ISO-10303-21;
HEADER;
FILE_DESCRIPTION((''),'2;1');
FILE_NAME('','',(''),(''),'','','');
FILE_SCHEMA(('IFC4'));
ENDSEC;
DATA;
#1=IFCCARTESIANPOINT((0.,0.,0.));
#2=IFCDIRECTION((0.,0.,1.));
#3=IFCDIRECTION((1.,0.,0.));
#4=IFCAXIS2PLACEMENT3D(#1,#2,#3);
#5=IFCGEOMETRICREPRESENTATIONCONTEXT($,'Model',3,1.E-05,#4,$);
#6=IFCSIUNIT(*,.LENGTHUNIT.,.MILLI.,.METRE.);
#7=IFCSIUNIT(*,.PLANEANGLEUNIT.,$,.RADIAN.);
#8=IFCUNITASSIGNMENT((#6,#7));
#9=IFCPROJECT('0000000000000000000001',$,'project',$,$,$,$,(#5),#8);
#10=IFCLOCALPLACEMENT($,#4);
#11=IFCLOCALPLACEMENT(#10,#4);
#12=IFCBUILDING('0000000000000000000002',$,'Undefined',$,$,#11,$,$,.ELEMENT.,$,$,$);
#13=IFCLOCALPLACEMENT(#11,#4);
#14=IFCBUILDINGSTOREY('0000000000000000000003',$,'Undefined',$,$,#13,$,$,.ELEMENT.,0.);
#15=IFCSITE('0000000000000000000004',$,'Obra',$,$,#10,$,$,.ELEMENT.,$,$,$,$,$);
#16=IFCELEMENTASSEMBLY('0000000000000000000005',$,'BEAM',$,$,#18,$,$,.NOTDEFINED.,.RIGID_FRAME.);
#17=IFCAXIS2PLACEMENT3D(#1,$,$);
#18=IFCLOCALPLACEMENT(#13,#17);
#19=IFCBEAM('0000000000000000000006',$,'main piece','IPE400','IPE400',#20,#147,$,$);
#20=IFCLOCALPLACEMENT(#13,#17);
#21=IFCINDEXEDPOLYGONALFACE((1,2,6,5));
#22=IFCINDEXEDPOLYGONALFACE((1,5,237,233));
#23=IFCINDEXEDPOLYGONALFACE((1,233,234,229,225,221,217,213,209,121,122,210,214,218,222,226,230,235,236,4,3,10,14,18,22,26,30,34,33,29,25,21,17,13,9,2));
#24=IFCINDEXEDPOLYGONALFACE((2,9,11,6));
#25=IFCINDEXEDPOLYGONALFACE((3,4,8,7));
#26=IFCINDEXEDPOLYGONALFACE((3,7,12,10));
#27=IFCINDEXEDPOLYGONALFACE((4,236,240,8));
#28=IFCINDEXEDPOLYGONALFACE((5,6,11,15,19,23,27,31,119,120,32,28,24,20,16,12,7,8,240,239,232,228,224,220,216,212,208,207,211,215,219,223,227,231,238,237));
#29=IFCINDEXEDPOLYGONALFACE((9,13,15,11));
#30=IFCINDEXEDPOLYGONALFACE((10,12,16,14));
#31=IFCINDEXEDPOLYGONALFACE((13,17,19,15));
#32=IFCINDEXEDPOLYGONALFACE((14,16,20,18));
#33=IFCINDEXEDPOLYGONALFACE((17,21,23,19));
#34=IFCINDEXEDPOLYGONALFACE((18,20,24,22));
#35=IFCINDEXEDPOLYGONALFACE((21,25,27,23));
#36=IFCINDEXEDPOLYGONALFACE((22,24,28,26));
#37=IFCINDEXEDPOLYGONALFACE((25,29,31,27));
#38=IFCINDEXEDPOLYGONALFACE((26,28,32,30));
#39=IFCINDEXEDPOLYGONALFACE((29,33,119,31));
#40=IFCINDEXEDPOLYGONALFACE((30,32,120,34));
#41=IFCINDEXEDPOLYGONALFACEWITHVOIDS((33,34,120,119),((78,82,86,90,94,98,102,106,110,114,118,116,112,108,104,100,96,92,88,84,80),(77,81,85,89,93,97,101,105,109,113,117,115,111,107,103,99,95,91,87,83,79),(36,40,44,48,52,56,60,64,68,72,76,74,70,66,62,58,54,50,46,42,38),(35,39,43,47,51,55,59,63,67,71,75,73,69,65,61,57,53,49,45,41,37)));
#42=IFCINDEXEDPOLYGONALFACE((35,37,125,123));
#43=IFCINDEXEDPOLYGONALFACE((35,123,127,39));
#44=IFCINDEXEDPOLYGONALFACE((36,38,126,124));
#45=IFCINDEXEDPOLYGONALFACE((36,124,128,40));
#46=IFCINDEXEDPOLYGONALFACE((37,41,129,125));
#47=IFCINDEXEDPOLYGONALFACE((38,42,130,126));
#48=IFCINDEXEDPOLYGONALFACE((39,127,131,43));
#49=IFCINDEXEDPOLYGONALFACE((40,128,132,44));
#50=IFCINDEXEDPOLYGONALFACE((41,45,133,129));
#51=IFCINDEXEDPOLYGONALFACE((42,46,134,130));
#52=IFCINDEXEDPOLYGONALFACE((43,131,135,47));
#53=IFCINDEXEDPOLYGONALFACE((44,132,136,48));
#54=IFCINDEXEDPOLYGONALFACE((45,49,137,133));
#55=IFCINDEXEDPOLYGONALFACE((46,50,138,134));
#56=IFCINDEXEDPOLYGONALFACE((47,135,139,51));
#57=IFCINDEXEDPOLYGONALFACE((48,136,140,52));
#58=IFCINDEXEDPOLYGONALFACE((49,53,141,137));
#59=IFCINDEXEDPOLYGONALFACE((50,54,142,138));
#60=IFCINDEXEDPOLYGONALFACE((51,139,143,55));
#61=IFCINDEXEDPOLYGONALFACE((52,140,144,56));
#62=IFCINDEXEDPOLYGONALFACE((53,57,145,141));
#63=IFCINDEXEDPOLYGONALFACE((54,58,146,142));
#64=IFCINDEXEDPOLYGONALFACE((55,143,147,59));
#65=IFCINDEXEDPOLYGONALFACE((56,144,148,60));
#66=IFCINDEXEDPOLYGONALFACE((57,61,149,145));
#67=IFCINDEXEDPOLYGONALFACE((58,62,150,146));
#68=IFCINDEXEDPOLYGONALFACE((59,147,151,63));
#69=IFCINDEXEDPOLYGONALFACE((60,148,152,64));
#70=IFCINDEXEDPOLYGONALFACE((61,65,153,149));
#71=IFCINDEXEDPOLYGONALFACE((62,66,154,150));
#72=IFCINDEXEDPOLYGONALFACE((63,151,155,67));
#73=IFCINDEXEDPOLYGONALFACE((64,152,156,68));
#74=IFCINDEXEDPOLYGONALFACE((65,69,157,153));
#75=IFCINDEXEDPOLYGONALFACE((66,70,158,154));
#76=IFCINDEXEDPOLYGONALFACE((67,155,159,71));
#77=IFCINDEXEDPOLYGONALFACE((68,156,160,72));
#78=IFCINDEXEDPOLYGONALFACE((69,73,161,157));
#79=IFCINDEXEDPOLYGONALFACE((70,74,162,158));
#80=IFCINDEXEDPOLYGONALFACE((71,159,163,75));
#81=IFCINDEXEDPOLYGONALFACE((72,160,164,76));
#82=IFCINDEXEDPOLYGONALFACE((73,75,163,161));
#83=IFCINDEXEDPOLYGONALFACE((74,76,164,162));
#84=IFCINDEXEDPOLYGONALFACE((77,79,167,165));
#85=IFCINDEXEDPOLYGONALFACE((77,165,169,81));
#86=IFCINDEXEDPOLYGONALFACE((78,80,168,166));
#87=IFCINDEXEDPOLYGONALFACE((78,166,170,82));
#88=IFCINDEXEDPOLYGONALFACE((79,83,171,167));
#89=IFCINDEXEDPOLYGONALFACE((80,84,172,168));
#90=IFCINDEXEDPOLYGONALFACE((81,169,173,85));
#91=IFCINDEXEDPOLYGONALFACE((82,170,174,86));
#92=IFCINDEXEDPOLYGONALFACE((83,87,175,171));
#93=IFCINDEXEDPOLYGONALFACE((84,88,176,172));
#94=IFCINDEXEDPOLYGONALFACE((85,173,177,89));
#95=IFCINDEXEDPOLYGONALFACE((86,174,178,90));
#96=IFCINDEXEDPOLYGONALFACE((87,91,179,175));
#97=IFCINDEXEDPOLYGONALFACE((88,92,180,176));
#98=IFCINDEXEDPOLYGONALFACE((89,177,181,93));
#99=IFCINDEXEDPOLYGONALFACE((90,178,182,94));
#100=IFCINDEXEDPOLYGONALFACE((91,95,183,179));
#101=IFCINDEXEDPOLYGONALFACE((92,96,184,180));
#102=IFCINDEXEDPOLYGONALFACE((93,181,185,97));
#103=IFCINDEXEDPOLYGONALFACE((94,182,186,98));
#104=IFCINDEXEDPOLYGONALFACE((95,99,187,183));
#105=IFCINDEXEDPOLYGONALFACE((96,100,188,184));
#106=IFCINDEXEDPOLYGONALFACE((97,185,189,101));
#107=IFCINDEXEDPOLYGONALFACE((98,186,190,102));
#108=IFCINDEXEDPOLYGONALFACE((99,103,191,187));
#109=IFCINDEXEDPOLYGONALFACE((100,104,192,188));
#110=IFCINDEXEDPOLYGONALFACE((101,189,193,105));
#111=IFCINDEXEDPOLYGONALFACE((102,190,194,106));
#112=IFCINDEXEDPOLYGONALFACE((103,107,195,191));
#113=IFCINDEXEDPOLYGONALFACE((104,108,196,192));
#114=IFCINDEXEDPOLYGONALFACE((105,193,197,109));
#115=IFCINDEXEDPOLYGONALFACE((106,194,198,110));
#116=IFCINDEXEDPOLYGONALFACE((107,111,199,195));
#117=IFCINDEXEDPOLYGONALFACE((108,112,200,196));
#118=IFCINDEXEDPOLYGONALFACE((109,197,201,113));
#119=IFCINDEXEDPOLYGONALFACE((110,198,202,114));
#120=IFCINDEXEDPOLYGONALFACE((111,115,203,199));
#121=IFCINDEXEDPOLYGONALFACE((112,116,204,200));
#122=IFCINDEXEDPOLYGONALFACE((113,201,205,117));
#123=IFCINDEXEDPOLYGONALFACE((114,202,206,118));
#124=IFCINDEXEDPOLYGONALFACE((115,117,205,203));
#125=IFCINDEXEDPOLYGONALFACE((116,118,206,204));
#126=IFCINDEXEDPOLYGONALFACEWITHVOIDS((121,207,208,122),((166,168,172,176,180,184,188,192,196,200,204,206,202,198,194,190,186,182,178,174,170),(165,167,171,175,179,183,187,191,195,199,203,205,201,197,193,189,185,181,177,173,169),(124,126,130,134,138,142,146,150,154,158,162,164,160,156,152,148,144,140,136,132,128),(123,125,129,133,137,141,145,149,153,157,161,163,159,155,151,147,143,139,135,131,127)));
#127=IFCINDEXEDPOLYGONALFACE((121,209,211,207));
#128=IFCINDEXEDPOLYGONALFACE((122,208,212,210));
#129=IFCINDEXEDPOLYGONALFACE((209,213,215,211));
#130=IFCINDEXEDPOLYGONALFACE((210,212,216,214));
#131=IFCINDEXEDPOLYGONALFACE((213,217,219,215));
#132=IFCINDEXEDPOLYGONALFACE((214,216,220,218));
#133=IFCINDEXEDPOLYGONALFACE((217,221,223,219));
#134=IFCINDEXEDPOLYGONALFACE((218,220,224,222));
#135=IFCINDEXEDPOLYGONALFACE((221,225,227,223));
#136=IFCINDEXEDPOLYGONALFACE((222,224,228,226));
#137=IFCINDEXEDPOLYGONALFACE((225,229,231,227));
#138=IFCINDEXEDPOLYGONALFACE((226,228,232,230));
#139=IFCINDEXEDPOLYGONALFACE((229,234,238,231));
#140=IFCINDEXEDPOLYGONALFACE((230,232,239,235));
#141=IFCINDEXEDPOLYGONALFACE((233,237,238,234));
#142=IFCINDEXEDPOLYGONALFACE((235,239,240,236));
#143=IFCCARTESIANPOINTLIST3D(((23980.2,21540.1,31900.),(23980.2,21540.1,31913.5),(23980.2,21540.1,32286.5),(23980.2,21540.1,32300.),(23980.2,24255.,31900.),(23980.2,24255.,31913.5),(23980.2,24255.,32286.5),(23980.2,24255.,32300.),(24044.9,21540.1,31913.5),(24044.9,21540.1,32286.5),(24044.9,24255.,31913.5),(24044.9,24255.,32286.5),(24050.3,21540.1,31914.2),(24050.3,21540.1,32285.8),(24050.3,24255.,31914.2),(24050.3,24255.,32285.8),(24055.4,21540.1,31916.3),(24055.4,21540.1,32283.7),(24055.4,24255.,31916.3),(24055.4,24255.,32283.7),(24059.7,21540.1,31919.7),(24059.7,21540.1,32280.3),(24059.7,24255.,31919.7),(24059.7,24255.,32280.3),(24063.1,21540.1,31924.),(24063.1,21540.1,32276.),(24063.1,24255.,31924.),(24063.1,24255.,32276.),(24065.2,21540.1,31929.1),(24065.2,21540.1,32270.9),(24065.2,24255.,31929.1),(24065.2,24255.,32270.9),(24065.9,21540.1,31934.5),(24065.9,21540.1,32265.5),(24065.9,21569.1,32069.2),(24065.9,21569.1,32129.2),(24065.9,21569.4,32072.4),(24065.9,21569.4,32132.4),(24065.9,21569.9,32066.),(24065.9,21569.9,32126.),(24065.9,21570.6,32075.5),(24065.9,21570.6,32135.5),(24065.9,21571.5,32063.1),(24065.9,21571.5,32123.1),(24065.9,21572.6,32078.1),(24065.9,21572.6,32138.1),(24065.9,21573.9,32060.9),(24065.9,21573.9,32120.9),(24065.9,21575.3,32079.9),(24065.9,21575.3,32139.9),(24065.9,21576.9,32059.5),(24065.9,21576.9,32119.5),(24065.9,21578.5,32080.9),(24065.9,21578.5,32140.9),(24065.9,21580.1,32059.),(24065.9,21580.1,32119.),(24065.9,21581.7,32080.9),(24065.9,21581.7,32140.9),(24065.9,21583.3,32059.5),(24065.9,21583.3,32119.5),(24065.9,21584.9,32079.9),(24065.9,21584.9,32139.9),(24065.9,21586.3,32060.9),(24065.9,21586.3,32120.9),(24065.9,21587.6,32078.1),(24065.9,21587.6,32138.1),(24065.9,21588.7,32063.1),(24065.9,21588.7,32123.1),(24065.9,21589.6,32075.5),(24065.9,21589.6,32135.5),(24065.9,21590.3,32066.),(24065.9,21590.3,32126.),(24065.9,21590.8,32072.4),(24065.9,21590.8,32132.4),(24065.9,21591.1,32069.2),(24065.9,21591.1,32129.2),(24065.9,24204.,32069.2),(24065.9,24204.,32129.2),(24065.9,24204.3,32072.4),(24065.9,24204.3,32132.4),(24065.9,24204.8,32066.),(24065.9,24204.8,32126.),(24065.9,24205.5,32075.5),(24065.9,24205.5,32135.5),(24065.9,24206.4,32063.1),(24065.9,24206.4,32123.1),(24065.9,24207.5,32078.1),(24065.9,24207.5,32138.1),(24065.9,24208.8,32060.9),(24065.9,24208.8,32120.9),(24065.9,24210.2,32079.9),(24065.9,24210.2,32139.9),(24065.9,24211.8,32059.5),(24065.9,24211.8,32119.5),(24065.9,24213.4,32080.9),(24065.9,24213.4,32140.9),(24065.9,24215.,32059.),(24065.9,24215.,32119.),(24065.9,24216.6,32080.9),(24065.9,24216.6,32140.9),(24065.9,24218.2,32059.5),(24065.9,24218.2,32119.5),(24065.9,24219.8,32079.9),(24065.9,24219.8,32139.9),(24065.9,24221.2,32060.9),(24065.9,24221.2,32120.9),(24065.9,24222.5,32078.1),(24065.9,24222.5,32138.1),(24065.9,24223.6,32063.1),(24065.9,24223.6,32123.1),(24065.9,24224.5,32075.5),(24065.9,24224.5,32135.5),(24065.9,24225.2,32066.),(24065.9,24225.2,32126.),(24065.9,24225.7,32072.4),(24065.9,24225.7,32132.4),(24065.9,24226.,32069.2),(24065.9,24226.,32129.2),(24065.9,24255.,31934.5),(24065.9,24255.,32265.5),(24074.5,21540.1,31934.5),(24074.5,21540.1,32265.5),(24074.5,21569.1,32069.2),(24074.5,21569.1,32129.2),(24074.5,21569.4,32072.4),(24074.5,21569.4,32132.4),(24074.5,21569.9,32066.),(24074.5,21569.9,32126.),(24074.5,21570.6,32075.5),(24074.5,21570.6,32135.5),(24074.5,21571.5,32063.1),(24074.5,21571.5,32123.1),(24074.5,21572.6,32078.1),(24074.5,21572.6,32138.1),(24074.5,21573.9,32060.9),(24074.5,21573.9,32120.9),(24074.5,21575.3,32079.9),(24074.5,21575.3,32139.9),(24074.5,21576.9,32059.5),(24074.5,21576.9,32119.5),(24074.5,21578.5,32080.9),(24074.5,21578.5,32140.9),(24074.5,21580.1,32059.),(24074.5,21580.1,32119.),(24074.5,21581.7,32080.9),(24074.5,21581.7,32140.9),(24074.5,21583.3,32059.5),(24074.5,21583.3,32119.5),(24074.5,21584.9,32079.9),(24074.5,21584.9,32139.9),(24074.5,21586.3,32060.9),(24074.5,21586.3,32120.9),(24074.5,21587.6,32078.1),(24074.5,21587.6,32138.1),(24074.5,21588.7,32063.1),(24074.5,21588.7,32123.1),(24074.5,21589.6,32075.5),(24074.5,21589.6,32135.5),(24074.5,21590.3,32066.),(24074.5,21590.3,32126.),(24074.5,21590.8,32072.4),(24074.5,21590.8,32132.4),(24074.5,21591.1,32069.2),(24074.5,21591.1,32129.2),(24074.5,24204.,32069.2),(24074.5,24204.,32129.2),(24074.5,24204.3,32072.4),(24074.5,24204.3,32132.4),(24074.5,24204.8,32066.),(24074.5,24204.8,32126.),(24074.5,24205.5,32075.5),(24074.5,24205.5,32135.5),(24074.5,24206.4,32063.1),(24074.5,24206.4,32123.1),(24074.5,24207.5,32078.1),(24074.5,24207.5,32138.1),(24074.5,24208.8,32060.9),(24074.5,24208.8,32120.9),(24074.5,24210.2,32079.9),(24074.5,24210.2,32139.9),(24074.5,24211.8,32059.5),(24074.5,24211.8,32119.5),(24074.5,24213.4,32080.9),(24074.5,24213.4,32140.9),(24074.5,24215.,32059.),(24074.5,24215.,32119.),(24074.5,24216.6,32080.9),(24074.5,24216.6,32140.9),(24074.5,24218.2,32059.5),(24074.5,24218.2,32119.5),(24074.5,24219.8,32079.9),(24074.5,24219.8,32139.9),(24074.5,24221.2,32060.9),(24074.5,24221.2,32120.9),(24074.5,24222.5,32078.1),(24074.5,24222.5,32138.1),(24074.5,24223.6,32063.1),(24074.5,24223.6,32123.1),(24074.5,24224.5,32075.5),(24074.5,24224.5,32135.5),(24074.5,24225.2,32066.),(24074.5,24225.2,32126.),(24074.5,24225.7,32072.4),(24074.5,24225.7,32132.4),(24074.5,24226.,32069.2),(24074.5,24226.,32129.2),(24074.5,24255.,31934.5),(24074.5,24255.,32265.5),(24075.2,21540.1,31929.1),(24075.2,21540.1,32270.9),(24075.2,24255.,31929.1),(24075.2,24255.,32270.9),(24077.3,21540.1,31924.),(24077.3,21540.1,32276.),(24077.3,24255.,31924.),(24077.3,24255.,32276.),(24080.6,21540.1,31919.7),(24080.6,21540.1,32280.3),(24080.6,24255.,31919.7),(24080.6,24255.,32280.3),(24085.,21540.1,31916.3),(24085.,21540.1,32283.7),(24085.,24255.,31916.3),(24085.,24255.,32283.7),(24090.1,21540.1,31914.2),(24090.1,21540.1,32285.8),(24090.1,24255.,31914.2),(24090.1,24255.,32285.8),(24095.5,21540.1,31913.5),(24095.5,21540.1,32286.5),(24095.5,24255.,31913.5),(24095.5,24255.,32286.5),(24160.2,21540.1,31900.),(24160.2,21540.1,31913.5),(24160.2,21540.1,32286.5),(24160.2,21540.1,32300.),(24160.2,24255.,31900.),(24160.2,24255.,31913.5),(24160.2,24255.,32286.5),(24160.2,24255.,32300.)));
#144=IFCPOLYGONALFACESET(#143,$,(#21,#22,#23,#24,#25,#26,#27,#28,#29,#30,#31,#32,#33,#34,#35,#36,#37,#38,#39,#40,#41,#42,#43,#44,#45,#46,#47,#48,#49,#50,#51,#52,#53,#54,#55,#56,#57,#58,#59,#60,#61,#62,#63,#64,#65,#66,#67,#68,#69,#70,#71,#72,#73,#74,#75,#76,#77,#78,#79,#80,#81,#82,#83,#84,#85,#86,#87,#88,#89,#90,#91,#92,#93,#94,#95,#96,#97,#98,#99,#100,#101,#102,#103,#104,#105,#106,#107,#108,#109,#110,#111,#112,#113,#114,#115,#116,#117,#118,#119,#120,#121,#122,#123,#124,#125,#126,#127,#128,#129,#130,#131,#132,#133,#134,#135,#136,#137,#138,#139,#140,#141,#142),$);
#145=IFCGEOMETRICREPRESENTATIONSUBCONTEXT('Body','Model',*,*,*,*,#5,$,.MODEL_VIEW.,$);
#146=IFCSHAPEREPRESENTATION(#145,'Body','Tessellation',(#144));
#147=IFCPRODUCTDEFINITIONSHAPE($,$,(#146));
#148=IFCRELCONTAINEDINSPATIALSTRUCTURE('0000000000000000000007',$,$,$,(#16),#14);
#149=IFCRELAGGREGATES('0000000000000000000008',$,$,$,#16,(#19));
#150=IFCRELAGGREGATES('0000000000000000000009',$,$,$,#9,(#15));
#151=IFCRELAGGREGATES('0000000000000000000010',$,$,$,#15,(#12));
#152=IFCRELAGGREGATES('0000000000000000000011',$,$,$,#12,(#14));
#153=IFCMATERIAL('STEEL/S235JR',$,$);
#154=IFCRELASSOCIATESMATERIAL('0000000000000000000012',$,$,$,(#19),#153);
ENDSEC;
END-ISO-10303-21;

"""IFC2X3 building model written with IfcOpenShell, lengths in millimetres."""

from ifc_helpers import new_model, si_unit, frame, origin_with_axes, origin_2d_with_axis, place, context, subcontext, project, spatial, rectangle, circle, i_section, extrude, clip, halfspace, source, transform, mapped, material, element, aggregate, save


model = new_model("IFC2X3")

# Units and contexts
model_context = context("Model", 3, precision=1e-05, world=origin_with_axes())
body_context = subcontext(model_context, "Body", "Model", "MODEL_VIEW")
ifc_project = project(units=[si_unit("LENGTHUNIT", "METRE", prefix="MILLI"), si_unit("PLANEANGLEUNIT", "RADIAN")], contexts=[model_context])

# Site, building, storey
site_placement = place(None, origin_with_axes())
site = spatial("IfcSite", under=ifc_project, at=site_placement, Name="Obra", CompositionType="ELEMENT")
building_placement = place(site_placement, origin_with_axes())
building = spatial("IfcBuilding", under=site, at=building_placement, Name="Undefined", CompositionType="ELEMENT")
storey_placement = place(building_placement, origin_with_axes())
storey = spatial("IfcBuildingStorey", under=building, at=storey_placement, Name="Undefined", CompositionType="ELEMENT", Elevation=0.0)

# Shared definitions
ifc_material_1 = material(Name="STEEL/S235JR")

# Element assembly, beam, openings
assembly_1_placement = place(storey_placement, origin_with_axes())
assembly_1 = element("IfcElementAssembly", 1, at=assembly_1_placement, inside=storey, Name="BEAM", AssemblyPlace="NOTDEFINED", PredefinedType="RIGID_FRAME")
beam_1_placement = place(assembly_1_placement, frame((24070.2, 21550.1, 32100.0), z_axis=(0.0, 0.0, 1.0), x_axis=(0.0, 1.0, 0.0)))
beam_1 = element("IfcBeam", 2, at=beam_1_placement, material=ifc_material_1, Name="main piece", Description="IPE400", ObjectType="IPE400", context=body_context, shape_type="Clipping", body=[
    clip(clip(extrude(i_section(OverallWidth=180.0, OverallDepth=400.0, WebThickness=8.6, FlangeThickness=13.5, FilletRadius=21.0, at=origin_2d_with_axis()), frame((2704.9, 0.0, 0.0), z_axis=(-1.0, 0.0, 0.0), x_axis=(0.0, -1.0, 0.0)), (0.0, 0.0, 1.0), 2714.9), halfspace(frame((2704.9, 0.0, -300.0), z_axis=(-1.0, -0.000001, 0.0), x_axis=(-0.000002, 1.0, 0.0)), True)), halfspace(frame((-10.0, 0.0, -300.0), z_axis=(1.0, 0.0, 0.0), x_axis=(0.0, -1.0, 0.0)), True)),
])
opening_1_placement = place(assembly_1_placement, frame((24070.2, 21550.1, 32100.0), z_axis=(0.0, 0.0, 1.0), x_axis=(0.0, 1.0, 0.0)))
element("IfcOpeningElement", 3, at=opening_1_placement, cuts=beam_1, ObjectType="Recess", context=body_context, shape_type="SweptSolid", body=[
    extrude(rectangle(XDim=35.5, YDim=97.7, at=origin_2d_with_axis()), frame((-58.9, -91.0, -183.2), z_axis=(0.0, 1.0, 0.0), x_axis=(0.0, 0.0, -1.0)), (0.0, 0.0, 1.0), 182.0),
])
opening_2_placement = place(assembly_1_placement, frame((24070.2, 21550.1, 32100.0), z_axis=(0.0, 0.0, 1.0), x_axis=(0.0, 1.0, 0.0)))
element("IfcOpeningElement", 4, at=opening_2_placement, cuts=beam_1, ObjectType="Recess", context=body_context, shape_type="SweptSolid", body=[
    extrude(rectangle(XDim=35.5, YDim=97.7, at=origin_2d_with_axis()), frame((-58.9, -91.0, 183.2), z_axis=(0.0, 1.0, 0.0), x_axis=(0.0, 0.0, -1.0)), (0.0, 0.0, 1.0), 182.0),
])
opening_3_placement = place(assembly_1_placement, frame((24070.2, 21550.1, 32100.0), z_axis=(0.0, 0.0, 1.0), x_axis=(0.0, 1.0, 0.0)))
element("IfcOpeningElement", 5, at=opening_3_placement, cuts=beam_1, ObjectType="Recess", context=body_context, shape_type="SweptSolid", body=[
    extrude(rectangle(XDim=35.5, YDim=97.7, at=origin_2d_with_axis()), frame((2753.7, 91.0, -183.2), z_axis=(0.000001, -1.0, 0.0), x_axis=(0.0, 0.0, -1.0)), (0.0, 0.0, 1.0), 182.0),
])
opening_4_placement = place(assembly_1_placement, frame((24070.2, 21550.1, 32100.0), z_axis=(0.0, 0.0, 1.0), x_axis=(0.0, 1.0, 0.0)))
element("IfcOpeningElement", 6, at=opening_4_placement, cuts=beam_1, ObjectType="Recess", context=body_context, shape_type="SweptSolid", body=[
    extrude(rectangle(XDim=35.5, YDim=97.7, at=origin_2d_with_axis()), frame((2753.7, 91.0, 183.2), z_axis=(0.000001, -1.0, 0.0), x_axis=(0.0, 0.0, -1.0)), (0.0, 0.0, 1.0), 182.0),
])
shared_shape_1 = source(origin_with_axes(), body_context, "Body", "SweptSolid", [
    extrude(circle(Radius=11.0, at=origin_2d_with_axis()), frame((0.0, -4.4, 0.0), z_axis=(0.0, 1.0, 0.0), x_axis=(1.0, 0.0, 0.0)), (0.0, 0.0, 1.0), 8.8),
])
opening_5_placement = place(assembly_1_placement, frame((24070.2, 21540.1, 32170.0), z_axis=(0.0, 1.0, 0.0), x_axis=(0.0, 0.0, -1.0)))
element("IfcOpeningElement", 7, at=opening_5_placement, cuts=beam_1, ObjectType="Opening", context=body_context, shape_type="MappedRepresentation", body=[
    mapped(shared_shape_1, transform((40.0, 0.0, 40.0))),
    mapped(shared_shape_1, transform((100.0, 0.0, 40.0))),
])
shared_shape_2 = source(origin_with_axes(), body_context, "Body", "SweptSolid", [
    extrude(circle(Radius=11.0, at=origin_2d_with_axis()), frame((0.0, -4.4, 0.0), z_axis=(0.0, 1.0, 0.0), x_axis=(1.0, 0.0, 0.0)), (0.0, 0.0, 1.0), 8.8),
])
opening_6_placement = place(assembly_1_placement, frame((24070.2, 24255.0, 32170.0), z_axis=(0.000001, -1.0, 0.0), x_axis=(0.0, 0.0, -1.0)))
element("IfcOpeningElement", 8, at=opening_6_placement, cuts=beam_1, ObjectType="Opening", context=body_context, shape_type="MappedRepresentation", body=[
    mapped(shared_shape_2, transform((40.0, 0.0, 40.0))),
    mapped(shared_shape_2, transform((100.0, 0.0, 40.0))),
])

aggregate(assembly_1, [beam_1])

save(model, "model.ifc")
